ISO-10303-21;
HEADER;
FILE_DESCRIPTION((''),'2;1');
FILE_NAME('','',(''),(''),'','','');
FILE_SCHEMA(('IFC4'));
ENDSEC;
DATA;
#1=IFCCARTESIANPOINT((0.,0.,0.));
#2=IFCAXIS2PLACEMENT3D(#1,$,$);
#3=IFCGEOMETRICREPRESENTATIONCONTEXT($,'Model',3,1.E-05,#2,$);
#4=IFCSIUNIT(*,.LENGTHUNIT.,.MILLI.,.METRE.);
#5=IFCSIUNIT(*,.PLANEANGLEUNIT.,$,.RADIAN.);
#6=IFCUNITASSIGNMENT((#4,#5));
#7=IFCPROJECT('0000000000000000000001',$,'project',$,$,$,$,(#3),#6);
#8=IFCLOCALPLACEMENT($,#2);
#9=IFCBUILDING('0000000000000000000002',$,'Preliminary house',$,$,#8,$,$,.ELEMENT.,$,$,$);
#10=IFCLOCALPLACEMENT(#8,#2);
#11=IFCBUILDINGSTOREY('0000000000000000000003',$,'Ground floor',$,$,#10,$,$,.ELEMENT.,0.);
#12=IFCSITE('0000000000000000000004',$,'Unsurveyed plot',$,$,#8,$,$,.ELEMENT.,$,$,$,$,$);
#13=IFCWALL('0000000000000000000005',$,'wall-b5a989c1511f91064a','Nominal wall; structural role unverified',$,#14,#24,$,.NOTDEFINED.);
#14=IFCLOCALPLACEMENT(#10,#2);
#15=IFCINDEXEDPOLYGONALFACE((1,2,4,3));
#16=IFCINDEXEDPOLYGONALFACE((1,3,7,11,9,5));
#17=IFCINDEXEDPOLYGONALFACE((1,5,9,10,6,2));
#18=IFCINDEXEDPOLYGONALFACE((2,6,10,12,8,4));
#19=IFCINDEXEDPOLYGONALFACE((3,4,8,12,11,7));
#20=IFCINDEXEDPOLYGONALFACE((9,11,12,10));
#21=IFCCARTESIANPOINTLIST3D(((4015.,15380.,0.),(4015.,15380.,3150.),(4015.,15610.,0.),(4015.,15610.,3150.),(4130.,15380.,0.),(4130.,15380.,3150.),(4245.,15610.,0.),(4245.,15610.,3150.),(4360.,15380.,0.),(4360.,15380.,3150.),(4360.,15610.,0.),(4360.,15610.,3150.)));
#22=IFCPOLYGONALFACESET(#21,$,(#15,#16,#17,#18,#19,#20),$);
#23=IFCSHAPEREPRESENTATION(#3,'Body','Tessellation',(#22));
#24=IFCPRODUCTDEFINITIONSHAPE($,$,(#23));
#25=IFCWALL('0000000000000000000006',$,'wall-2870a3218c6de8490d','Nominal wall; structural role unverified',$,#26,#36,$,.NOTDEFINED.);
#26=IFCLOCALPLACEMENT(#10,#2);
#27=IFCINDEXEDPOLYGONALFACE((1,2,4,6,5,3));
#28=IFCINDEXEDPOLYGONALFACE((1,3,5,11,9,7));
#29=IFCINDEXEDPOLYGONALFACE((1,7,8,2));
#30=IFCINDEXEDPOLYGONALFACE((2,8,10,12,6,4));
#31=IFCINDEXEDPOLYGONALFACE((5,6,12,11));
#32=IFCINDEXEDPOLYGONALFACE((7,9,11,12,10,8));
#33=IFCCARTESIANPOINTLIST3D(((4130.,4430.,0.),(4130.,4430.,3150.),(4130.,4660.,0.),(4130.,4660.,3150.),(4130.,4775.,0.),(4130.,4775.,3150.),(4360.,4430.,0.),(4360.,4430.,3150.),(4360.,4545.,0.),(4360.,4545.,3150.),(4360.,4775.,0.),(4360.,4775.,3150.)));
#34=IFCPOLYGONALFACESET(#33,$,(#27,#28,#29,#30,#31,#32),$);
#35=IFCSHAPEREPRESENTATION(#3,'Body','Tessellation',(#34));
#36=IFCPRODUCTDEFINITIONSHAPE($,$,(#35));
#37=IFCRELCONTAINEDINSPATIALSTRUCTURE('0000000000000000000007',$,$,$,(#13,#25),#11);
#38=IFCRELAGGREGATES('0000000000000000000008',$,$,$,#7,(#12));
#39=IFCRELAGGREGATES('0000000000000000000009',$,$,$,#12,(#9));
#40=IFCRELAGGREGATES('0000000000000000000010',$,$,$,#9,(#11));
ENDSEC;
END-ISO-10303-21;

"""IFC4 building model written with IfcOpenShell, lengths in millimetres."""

from ifc_helpers import new_model, si_unit, origin, place, context, project, spatial, polyline, outline, extrude, element, save


model = new_model("IFC4")

# Units and contexts
model_context = context("Model", 3, precision=1e-05, world=origin())
ifc_project = project(units=[si_unit("LENGTHUNIT", "METRE", prefix="MILLI"), si_unit("PLANEANGLEUNIT", "RADIAN")], contexts=[model_context])

# Site, building, storey
placement_1 = place(None, origin())
site = spatial("IfcSite", under=ifc_project, at=placement_1, Name="Unsurveyed plot", CompositionType="ELEMENT")
building = spatial("IfcBuilding", under=site, at=placement_1, Name="Preliminary house", CompositionType="ELEMENT")
placement_2 = place(placement_1, origin())
storey = spatial("IfcBuildingStorey", under=building, at=placement_2, Name="Ground floor", CompositionType="ELEMENT", Elevation=0.0)

# Wall
element("IfcWall", 1, at=placement_2, inside=storey, Name="wall-b5a989c1511f91064a", Description="Nominal wall; structural role unverified", PredefinedType="NOTDEFINED", context=model_context, shape_type="SweptSolid", body=[
    extrude(outline(polyline([(4245.0, 15610.0), (4360.0, 15610.0), (4360.0, 15380.0), (4130.0, 15380.0), (4015.0, 15380.0), (4015.0, 15610.0), (4245.0, 15610.0)])), origin(), (0.0, 0.0, 1.0), 3150.0),
])

# Wall
element("IfcWall", 2, at=placement_2, inside=storey, Name="wall-2870a3218c6de8490d", Description="Nominal wall; structural role unverified", PredefinedType="NOTDEFINED", context=model_context, shape_type="SweptSolid", body=[
    extrude(outline(polyline([(4130.0, 4660.0), (4130.0, 4775.0), (4360.0, 4775.0), (4360.0, 4545.0), (4360.0, 4430.0), (4130.0, 4430.0), (4130.0, 4660.0)])), origin(), (0.0, 0.0, 1.0), 3150.0),
])

save(model, "model.ifc")
